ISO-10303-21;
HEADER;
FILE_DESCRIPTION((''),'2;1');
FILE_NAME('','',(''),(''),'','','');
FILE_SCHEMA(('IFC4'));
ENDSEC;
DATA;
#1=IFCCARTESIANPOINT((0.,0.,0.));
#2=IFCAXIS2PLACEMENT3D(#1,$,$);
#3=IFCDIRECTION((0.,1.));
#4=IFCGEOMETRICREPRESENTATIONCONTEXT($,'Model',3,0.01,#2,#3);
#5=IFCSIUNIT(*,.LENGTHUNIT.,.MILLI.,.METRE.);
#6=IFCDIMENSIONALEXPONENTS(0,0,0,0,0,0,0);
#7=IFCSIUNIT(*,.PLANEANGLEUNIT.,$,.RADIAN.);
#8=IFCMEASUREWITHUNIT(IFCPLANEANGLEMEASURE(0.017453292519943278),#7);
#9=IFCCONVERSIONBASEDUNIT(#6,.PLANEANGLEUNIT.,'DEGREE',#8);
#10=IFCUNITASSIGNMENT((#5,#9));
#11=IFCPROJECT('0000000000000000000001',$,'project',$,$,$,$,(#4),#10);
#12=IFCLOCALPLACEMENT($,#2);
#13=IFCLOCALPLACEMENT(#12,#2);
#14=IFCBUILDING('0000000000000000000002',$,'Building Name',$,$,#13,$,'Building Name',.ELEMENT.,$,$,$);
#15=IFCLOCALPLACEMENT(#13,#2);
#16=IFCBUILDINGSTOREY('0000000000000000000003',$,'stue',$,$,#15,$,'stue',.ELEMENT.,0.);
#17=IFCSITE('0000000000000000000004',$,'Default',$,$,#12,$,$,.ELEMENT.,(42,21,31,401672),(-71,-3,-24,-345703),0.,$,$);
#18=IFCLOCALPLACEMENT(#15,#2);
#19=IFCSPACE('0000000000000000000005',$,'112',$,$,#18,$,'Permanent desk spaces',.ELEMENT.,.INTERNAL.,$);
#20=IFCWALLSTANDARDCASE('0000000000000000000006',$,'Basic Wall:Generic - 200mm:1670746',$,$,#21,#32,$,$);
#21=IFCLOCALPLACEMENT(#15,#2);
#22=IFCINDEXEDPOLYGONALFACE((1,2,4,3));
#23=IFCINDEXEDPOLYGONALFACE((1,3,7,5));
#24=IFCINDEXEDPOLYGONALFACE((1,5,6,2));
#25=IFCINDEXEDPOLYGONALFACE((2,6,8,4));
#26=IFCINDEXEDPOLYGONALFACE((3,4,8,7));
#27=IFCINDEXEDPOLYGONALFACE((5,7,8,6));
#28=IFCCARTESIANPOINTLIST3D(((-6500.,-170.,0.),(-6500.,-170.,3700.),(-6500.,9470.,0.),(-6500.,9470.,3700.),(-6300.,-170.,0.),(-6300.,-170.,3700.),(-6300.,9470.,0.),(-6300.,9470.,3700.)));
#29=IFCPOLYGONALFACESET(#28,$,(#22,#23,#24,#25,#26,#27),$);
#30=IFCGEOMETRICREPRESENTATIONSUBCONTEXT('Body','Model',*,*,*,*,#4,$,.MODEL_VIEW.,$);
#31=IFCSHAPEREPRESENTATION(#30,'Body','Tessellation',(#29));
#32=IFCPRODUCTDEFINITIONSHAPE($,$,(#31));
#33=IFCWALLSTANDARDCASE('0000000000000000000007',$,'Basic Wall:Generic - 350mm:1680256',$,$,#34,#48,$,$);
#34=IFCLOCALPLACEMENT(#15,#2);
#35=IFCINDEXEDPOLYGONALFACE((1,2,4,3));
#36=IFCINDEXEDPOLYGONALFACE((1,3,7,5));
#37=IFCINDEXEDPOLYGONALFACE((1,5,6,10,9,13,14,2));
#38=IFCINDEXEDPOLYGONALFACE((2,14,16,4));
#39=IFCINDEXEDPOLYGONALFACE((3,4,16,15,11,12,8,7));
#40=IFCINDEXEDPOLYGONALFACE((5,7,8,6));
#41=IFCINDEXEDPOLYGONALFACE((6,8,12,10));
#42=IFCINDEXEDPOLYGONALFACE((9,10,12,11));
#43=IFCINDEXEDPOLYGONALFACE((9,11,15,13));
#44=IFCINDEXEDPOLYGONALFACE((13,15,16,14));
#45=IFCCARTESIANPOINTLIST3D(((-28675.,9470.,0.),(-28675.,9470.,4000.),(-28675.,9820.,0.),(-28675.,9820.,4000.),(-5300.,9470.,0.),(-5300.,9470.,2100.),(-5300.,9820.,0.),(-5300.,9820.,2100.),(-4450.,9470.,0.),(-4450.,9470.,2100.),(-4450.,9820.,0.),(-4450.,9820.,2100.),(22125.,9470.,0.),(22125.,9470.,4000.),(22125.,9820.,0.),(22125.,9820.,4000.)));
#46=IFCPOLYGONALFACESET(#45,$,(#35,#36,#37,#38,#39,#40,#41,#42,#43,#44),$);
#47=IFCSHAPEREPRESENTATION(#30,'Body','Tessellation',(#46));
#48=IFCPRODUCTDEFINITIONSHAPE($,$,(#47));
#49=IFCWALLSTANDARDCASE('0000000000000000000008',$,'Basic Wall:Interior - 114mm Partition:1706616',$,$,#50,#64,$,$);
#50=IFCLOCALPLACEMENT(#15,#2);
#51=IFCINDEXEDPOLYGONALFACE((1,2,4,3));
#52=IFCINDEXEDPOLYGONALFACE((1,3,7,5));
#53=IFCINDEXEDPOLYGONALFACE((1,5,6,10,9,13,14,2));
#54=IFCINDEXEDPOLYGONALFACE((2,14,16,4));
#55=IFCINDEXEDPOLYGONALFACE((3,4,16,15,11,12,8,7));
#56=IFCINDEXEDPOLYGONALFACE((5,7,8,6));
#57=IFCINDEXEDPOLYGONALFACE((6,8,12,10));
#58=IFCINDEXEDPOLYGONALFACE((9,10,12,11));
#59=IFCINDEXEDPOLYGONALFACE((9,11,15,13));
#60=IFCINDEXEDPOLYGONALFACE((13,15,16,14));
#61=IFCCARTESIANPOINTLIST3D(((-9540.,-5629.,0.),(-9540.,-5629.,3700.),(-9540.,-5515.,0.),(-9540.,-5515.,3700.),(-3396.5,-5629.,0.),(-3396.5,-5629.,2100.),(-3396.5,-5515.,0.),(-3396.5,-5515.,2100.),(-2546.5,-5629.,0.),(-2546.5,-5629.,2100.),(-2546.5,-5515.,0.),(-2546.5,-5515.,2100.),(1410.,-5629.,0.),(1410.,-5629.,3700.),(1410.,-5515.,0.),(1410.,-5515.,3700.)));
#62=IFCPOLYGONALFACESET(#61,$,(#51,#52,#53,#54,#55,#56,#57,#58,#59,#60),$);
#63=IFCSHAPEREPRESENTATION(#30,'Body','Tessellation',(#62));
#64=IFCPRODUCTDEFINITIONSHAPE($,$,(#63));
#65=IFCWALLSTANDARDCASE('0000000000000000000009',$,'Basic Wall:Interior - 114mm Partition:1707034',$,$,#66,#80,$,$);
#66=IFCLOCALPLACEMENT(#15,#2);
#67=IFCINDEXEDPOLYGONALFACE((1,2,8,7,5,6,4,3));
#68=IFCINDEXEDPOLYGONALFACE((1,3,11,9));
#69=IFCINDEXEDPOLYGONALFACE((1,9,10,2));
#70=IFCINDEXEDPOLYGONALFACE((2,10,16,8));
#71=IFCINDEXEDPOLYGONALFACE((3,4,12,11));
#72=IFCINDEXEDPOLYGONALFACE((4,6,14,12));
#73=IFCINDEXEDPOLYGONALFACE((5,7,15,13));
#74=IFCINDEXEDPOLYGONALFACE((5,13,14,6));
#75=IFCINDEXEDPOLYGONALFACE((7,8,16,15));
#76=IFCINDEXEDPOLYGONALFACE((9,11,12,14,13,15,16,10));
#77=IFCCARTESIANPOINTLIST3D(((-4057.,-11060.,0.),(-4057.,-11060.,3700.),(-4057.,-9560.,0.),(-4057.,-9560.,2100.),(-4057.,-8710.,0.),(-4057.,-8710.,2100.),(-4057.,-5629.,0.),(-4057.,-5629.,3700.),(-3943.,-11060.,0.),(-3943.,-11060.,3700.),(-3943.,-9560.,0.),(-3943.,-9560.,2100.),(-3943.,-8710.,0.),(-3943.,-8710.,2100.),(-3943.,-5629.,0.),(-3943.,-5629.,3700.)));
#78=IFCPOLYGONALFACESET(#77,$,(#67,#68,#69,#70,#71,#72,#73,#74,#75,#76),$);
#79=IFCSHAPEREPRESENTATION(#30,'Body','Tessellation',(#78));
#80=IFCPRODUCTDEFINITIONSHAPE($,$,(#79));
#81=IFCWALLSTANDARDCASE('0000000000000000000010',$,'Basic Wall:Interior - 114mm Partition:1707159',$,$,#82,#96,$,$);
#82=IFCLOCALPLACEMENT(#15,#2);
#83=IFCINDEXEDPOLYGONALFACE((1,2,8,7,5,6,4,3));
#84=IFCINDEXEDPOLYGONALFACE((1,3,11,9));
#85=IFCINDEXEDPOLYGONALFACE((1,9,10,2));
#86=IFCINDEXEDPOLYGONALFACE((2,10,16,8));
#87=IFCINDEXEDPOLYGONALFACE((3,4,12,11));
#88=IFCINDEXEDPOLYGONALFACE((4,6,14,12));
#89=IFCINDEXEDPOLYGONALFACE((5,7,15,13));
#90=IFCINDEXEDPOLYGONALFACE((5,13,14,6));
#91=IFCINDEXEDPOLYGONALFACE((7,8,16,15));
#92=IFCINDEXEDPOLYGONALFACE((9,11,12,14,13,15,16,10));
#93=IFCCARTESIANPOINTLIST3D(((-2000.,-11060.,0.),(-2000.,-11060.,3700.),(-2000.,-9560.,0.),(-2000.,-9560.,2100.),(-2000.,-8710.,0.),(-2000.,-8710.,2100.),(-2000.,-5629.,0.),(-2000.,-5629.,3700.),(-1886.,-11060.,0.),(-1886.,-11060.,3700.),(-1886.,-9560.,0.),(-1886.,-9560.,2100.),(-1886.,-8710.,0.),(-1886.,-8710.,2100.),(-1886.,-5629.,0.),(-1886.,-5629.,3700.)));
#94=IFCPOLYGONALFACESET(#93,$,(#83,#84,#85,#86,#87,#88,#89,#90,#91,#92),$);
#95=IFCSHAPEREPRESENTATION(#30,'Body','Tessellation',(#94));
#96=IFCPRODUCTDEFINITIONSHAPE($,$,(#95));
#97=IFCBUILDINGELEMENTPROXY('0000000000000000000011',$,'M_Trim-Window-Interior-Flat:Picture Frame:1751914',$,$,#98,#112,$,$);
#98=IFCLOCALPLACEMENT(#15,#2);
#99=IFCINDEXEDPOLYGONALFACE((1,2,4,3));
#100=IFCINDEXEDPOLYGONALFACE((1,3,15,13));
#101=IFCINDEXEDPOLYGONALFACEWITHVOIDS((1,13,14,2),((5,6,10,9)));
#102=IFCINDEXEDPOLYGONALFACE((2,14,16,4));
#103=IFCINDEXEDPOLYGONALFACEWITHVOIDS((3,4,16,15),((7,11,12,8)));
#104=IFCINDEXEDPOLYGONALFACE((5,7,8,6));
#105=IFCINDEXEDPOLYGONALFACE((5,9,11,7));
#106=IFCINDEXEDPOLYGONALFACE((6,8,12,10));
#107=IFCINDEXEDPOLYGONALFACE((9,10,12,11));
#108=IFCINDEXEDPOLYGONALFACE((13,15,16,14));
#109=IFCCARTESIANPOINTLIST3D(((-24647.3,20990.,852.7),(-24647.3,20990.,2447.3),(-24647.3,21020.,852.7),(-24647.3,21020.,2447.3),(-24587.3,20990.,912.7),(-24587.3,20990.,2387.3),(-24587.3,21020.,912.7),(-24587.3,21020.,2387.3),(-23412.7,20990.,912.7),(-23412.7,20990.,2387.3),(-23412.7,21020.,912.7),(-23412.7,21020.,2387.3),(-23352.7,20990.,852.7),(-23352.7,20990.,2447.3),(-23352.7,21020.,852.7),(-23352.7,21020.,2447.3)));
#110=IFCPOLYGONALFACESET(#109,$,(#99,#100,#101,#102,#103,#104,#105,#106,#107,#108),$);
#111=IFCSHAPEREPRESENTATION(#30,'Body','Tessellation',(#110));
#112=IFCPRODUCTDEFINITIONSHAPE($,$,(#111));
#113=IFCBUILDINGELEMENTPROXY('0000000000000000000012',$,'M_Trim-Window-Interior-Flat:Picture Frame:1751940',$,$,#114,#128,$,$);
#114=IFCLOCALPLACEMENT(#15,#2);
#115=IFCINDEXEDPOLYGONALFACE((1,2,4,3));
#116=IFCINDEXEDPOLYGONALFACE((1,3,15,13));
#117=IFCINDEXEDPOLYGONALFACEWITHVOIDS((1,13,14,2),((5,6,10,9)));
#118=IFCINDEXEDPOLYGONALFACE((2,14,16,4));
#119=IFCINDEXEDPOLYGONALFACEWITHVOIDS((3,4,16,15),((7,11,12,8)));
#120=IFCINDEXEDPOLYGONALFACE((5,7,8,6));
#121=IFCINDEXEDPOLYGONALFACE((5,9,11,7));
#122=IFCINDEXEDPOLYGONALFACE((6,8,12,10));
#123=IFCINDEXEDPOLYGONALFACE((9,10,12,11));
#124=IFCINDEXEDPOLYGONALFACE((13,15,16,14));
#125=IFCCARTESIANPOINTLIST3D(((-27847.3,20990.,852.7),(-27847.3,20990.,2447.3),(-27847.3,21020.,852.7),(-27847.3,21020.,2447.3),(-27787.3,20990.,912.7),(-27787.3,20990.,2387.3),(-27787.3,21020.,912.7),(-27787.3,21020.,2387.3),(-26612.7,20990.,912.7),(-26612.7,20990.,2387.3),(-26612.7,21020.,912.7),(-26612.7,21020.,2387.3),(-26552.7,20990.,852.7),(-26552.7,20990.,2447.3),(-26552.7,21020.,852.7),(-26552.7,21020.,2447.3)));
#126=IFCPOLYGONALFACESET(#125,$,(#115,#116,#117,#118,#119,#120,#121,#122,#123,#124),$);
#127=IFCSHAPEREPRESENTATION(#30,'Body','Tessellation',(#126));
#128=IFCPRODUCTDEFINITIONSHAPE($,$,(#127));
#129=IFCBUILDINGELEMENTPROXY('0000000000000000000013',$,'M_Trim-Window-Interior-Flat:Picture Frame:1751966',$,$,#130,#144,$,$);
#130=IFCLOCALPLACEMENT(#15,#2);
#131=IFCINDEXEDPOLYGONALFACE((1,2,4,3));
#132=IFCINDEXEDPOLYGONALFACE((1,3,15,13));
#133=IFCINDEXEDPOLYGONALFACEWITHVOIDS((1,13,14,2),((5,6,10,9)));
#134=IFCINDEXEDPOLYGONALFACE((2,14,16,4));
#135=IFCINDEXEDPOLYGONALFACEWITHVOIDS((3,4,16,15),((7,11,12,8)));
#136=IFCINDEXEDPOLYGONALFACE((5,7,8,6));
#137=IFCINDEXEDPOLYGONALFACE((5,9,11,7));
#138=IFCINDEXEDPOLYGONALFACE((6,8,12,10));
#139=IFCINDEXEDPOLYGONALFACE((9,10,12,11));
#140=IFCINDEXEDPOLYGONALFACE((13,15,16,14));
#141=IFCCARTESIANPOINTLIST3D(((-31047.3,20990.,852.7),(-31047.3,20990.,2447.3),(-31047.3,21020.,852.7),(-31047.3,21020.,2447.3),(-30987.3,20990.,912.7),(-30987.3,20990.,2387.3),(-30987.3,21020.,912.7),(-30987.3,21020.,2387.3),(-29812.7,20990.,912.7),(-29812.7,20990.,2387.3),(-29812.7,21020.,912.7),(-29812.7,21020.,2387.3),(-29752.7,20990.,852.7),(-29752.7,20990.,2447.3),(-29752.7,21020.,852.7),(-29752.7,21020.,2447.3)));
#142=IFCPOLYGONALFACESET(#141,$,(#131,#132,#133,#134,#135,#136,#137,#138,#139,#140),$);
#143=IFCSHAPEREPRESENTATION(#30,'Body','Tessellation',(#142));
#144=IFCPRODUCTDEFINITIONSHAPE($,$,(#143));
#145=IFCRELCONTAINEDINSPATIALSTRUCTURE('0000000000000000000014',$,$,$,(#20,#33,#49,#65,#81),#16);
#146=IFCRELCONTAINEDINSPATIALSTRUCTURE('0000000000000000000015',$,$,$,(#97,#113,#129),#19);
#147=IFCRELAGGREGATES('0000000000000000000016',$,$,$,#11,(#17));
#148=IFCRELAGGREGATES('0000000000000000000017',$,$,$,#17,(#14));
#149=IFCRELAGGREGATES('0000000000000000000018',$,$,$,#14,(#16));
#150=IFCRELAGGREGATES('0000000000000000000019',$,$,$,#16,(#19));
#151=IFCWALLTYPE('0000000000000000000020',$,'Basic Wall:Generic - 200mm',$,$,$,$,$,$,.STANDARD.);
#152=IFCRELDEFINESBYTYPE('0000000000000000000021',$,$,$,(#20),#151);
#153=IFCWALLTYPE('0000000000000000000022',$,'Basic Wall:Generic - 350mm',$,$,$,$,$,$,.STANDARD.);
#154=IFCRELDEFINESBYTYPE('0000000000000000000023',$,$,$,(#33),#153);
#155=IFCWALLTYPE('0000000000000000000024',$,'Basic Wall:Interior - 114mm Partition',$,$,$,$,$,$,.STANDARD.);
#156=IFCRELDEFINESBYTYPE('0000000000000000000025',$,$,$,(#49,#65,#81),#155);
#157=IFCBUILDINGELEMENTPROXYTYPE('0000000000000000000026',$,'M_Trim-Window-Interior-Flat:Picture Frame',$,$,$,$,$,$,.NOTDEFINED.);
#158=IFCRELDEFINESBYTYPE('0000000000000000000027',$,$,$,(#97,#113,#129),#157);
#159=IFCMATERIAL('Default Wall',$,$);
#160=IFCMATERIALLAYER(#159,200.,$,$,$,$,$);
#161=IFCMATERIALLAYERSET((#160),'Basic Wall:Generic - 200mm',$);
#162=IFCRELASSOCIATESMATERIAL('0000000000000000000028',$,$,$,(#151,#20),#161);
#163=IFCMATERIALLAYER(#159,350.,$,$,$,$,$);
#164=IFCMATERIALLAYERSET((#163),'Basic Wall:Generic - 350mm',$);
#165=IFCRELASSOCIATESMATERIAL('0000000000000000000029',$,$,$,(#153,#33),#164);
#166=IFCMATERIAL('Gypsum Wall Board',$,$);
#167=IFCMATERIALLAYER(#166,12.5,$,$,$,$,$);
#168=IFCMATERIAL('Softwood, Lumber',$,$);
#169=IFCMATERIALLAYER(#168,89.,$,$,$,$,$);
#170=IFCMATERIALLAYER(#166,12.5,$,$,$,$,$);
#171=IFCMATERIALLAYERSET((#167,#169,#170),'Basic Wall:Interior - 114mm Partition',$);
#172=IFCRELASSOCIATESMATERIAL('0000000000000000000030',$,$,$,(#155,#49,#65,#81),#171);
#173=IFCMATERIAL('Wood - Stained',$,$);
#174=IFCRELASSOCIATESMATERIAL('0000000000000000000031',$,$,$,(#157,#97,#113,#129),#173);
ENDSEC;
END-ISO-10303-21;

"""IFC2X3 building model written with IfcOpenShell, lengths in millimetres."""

from ifc_helpers import new_model, entity, si_unit, converted_unit, direction, frame, frame_2d, origin, place, context, subcontext, project, spatial, polyline, rectangle, outline, extrude, clip, bounded_halfspace, source, transform, mapped, material, layer, layer_set, layer_usage, type_object, type_shapes, element, save


model = new_model("IFC2X3")

# Units and contexts
model_context = context("Model", 3, precision=0.01, world=origin(), true_north=direction((0.0, 1.0)))
body_context = subcontext(model_context, "Body", "Model", "MODEL_VIEW")
ifc_project = project(units=[si_unit("LENGTHUNIT", "METRE", prefix="MILLI"), converted_unit("PLANEANGLEUNIT", "DEGREE", entity("IfcPlaneAngleMeasure", 0.017453292519943278), si_unit("PLANEANGLEUNIT", "RADIAN"), dimensions=[0, 0, 0, 0, 0, 0, 0])], contexts=[model_context])

# Site, building, storey
site_placement = place(None, origin())
site = spatial("IfcSite", under=ifc_project, at=site_placement, Name="Default", CompositionType="ELEMENT", RefLatitude=(42, 21, 31, 401672), RefLongitude=(-71, -3, -24, -345703), RefElevation=0.0)
building_placement = place(site_placement, origin())
building = spatial("IfcBuilding", under=site, at=building_placement, Name="Building Name", LongName="Building Name", CompositionType="ELEMENT")
storey_placement = place(building_placement, origin())
storey = spatial("IfcBuildingStorey", under=building, at=storey_placement, Name="stue", LongName="stue", CompositionType="ELEMENT", Elevation=0.0)

# Shared definitions
ifc_material_1 = material(Name="Default Wall")

# Wall
ifc_layer_1 = layer(ifc_material_1, 200.0)
ifc_layer_set_1 = layer_set([ifc_layer_1], Name="Basic Wall:Generic - 200mm")
ifc_layer_usage_1 = layer_usage(ifc_layer_set_1, "AXIS2", "NEGATIVE", 100.0)
wall_type_1 = type_object("IfcWallType", Name="Basic Wall:Generic - 200mm", PredefinedType="STANDARD", material=ifc_layer_set_1)
wall_1_placement = place(storey_placement, frame((-6400.0, 9470.0, 0.0), z_axis=(0.0, 0.0, 1.0), x_axis=(0.0, -1.0, 0.0)))
element("IfcWallStandardCase", 1, at=wall_1_placement, inside=storey, type_object=wall_type_1, material=ifc_layer_usage_1, Name="Basic Wall:Generic - 200mm:1670746", context=body_context, shape_type="Clipping", body=[
    clip(clip(extrude(rectangle(XDim=9640.0, YDim=200.0, at=frame_2d((4820.0, 0.0), x_axis=(-1.0, 0.0))), origin(), (0.0, 0.0, 1.0), 3700.0), bounded_halfspace(frame((0.0, -100.0, 3700.0), z_axis=(0.0, 0.0, -1.0), x_axis=(1.0, 0.0, 0.0)), True, frame((0.0, -100.0, 3700.0)), polyline([(0.0, 0.0), (9510.0, 0.0), (9510.0, 200.0), (0.0, 200.0), (0.0, 0.0)]))), bounded_halfspace(frame((9510.0, -100.0, 3700.0), z_axis=(0.0, 0.0, -1.0), x_axis=(1.0, 0.0, 0.0)), True, frame((9510.0, -100.0, 3700.0)), polyline([(0.0, 0.0), (130.0, 0.0), (130.0, 200.0), (0.0, 200.0), (0.0, 0.0)]))),
])

# Walls, openings
ifc_layer_2 = layer(ifc_material_1, 350.0)
ifc_layer_set_2 = layer_set([ifc_layer_2], Name="Basic Wall:Generic - 350mm")
ifc_layer_usage_2 = layer_usage(ifc_layer_set_2, "AXIS2", "NEGATIVE", 175.0)
wall_type_2 = type_object("IfcWallType", Name="Basic Wall:Generic - 350mm", PredefinedType="STANDARD", material=ifc_layer_set_2)
wall_2_placement = place(storey_placement, frame((-28675.0, 9645.0, 0.0)))
wall_2 = element("IfcWallStandardCase", 2, at=wall_2_placement, inside=storey, type_object=wall_type_2, material=ifc_layer_usage_2, Name="Basic Wall:Generic - 350mm:1680256", context=body_context, shape_type="SweptSolid", body=[
    extrude(rectangle(XDim=50800.0, YDim=350.0, at=frame_2d((25400.0, 0.0), x_axis=(1.0, 0.0))), origin(), (0.0, 0.0, 1.0), 4000.0),
])
opening_1_placement = place(wall_2_placement, frame((24225.0, 175.0, 0.0)))
element("IfcOpeningElement", 3, at=opening_1_placement, cuts=wall_2, ObjectType="Opening", context=body_context, shape_type="SweptSolid", body=[
    extrude(rectangle(XDim=2100.0, YDim=850.0, at=frame_2d((1050.0, 425.0), x_axis=(1.0, 0.0))), frame((0.0, 0.0, 0.0), z_axis=(0.0, -1.0, 0.0), x_axis=(0.0, 0.0, 1.0)), (0.0, 0.0, 1.0), 350.0),
])
ifc_material_2 = material(Name="Gypsum Wall Board")
ifc_layer_3 = layer(ifc_material_2, 12.5)
ifc_material_3 = material(Name="Softwood, Lumber")
ifc_layer_4 = layer(ifc_material_3, 89.0)
ifc_layer_5 = layer(ifc_material_2, 12.5)
ifc_layer_set_3 = layer_set([ifc_layer_3, ifc_layer_4, ifc_layer_5], Name="Basic Wall:Interior - 114mm Partition")
ifc_layer_usage_3 = layer_usage(ifc_layer_set_3, "AXIS2", "NEGATIVE", 57.0)
wall_type_3 = type_object("IfcWallType", Name="Basic Wall:Interior - 114mm Partition", PredefinedType="STANDARD", material=ifc_layer_set_3)
wall_3_placement = place(storey_placement, frame((-9540.0, -5572.0, 0.0)))
wall_3 = element("IfcWallStandardCase", 4, at=wall_3_placement, inside=storey, type_object=wall_type_3, material=ifc_layer_usage_3, Name="Basic Wall:Interior - 114mm Partition:1706616", context=body_context, shape_type="Clipping", body=[
    clip(extrude(rectangle(XDim=10950.0, YDim=114.0, at=frame_2d((5475.0, 0.0), x_axis=(1.0, 0.0))), origin(), (0.0, 0.0, 1.0), 3700.0), bounded_halfspace(frame((0.0, -57.0, 3700.0), z_axis=(0.0, 0.0, -1.0), x_axis=(0.0, -1.0, 0.0)), True, frame((0.0, -57.0, 3700.0)), polyline([(0.0, 0.0), (5483.0, 0.0), (5597.0, 0.0), (7540.0, 0.0), (7654.0, 0.0), (10950.0, 0.0), (10950.0, 114.0), (0.0, 114.0), (0.0, 0.0)]))),
])
opening_2_placement = place(wall_3_placement, frame((6143.5, -57.0, 0.0)))
element("IfcOpeningElement", 5, at=opening_2_placement, cuts=wall_3, ObjectType="Opening", context=body_context, shape_type="SweptSolid", body=[
    extrude(rectangle(XDim=2100.0, YDim=850.0, at=frame_2d((1050.0, 425.0), x_axis=(1.0, 0.0))), frame((0.0, 0.0, 0.0), z_axis=(0.0, 1.0, 0.0), x_axis=(0.0, 0.0, 1.0)), (0.0, 0.0, 1.0), 114.0),
])
ifc_layer_usage_4 = layer_usage(ifc_layer_set_3, "AXIS2", "NEGATIVE", 57.0)
wall_4_placement = place(storey_placement, frame((-4000.0, -5629.0, 0.0), z_axis=(0.0, 0.0, 1.0), x_axis=(0.0, -1.0, 0.0)))
wall_4 = element("IfcWallStandardCase", 6, at=wall_4_placement, inside=storey, type_object=wall_type_3, material=ifc_layer_usage_4, Name="Basic Wall:Interior - 114mm Partition:1707034", context=body_context, shape_type="Clipping", body=[
    clip(extrude(rectangle(XDim=5431.0, YDim=114.0, at=frame_2d((2715.5, 0.0), x_axis=(1.0, 0.0))), origin(), (0.0, 0.0, 1.0), 3700.0), bounded_halfspace(frame((0.0, -57.0, 3700.0), z_axis=(0.0, 0.0, -1.0), x_axis=(1.0, 0.0, 0.0)), True, frame((0.0, -57.0, 3700.0)), polyline([(0.0, 0.0), (5431.0, 0.0), (5431.0, 114.0), (0.0, 114.0), (0.0, 0.0)]))),
])
opening_3_placement = place(wall_4_placement, frame((3931.0, 57.0, 0.0)))
element("IfcOpeningElement", 7, at=opening_3_placement, cuts=wall_4, ObjectType="Opening", context=body_context, shape_type="SweptSolid", body=[
    extrude(rectangle(XDim=2100.0, YDim=850.0, at=frame_2d((1050.0, 425.0), x_axis=(1.0, 0.0))), frame((0.0, 0.0, 0.0), z_axis=(0.0, -1.0, 0.0), x_axis=(0.0, 0.0, 1.0)), (0.0, 0.0, 1.0), 114.0),
])
ifc_layer_usage_5 = layer_usage(ifc_layer_set_3, "AXIS2", "NEGATIVE", 57.0)
wall_5_placement = place(storey_placement, frame((-1943.0, -5629.0, 0.0), z_axis=(0.0, 0.0, 1.0), x_axis=(0.0, -1.0, 0.0)))
wall_5 = element("IfcWallStandardCase", 8, at=wall_5_placement, inside=storey, type_object=wall_type_3, material=ifc_layer_usage_5, Name="Basic Wall:Interior - 114mm Partition:1707159", context=body_context, shape_type="Clipping", body=[
    clip(extrude(rectangle(XDim=5431.0, YDim=114.0, at=frame_2d((2715.5, 0.0), x_axis=(1.0, 0.0))), origin(), (0.0, 0.0, 1.0), 3700.0), bounded_halfspace(frame((0.0, -57.0, 3700.0), z_axis=(0.0, 0.0, -1.0), x_axis=(1.0, 0.0, 0.0)), True, frame((0.0, -57.0, 3700.0)), polyline([(0.0, 0.0), (5431.0, 0.0), (5431.0, 114.0), (0.0, 114.0), (0.0, 0.0)]))),
])
opening_4_placement = place(wall_5_placement, frame((3081.0, -57.0, 0.0)))
element("IfcOpeningElement", 9, at=opening_4_placement, cuts=wall_5, ObjectType="Opening", context=body_context, shape_type="SweptSolid", body=[
    extrude(rectangle(XDim=2100.0, YDim=850.0, at=frame_2d((1050.0, 425.0), x_axis=(1.0, 0.0))), frame((0.0, 0.0, 0.0), z_axis=(0.0, 1.0, 0.0), x_axis=(0.0, 0.0, 1.0)), (0.0, 0.0, 1.0), 114.0),
])

# Shared definitions
space_placement = place(storey_placement, origin())
space = spatial("IfcSpace", under=storey, at=space_placement, Name="112", LongName="Permanent desk spaces", CompositionType="ELEMENT", InteriorOrExteriorSpace="INTERNAL")

# Building element proxies
ifc_material_4 = material(Name="Wood - Stained")
building_element_proxy_type = type_object("IfcBuildingElementProxyType", Name="M_Trim-Window-Interior-Flat:Picture Frame", PredefinedType="NOTDEFINED", material=ifc_material_4)
shared_shape_1 = source(origin(), body_context, "Body", "SweptSolid", [
    extrude(outline(polyline([(-647.3, -797.3), (647.3, -797.3), (647.3, 797.3), (-647.3, 797.3), (-647.3, -797.3)]), holes=[polyline([(-587.3, -737.3), (-587.3, 737.3), (587.3, 737.3), (587.3, -737.3), (-587.3, -737.3)])]), frame((0.0, -750.0, 0.0), z_axis=(0.0, 0.0, 1.0), x_axis=(-1.0, 0.0, 0.0)), (0.0, 0.0, 1.0), 30.0),
])
type_shapes(building_element_proxy_type, [shared_shape_1])
for number, where, z_axis, x_axis, name in (
    (10, (-24000.0, 21020.0, 2400.0), (0.0, -1.0, 0.0), (1.0, 0.0, 0.0), "M_Trim-Window-Interior-Flat:Picture Frame:1751914"),
    (11, (-27200.0, 21020.0, 2400.0), (0.0, -1.0, 0.0), (1.0, 0.0, 0.0), "M_Trim-Window-Interior-Flat:Picture Frame:1751940"),
    (12, (-30400.0, 21020.0, 2400.0), (0.0, -1.0, 0.0), (1.0, 0.0, 0.0), "M_Trim-Window-Interior-Flat:Picture Frame:1751966"),
):
    element("IfcBuildingElementProxy", number, at=place(space_placement, frame(where, z_axis=z_axis, x_axis=x_axis)), inside=space, type_object=building_element_proxy_type, material=ifc_material_4, Name=name, context=body_context, shape_type="MappedRepresentation", body=[
        mapped(shared_shape_1, transform((0.0, 0.0, 0.0), scale=1.0)),
    ])

save(model, "model.ifc")
